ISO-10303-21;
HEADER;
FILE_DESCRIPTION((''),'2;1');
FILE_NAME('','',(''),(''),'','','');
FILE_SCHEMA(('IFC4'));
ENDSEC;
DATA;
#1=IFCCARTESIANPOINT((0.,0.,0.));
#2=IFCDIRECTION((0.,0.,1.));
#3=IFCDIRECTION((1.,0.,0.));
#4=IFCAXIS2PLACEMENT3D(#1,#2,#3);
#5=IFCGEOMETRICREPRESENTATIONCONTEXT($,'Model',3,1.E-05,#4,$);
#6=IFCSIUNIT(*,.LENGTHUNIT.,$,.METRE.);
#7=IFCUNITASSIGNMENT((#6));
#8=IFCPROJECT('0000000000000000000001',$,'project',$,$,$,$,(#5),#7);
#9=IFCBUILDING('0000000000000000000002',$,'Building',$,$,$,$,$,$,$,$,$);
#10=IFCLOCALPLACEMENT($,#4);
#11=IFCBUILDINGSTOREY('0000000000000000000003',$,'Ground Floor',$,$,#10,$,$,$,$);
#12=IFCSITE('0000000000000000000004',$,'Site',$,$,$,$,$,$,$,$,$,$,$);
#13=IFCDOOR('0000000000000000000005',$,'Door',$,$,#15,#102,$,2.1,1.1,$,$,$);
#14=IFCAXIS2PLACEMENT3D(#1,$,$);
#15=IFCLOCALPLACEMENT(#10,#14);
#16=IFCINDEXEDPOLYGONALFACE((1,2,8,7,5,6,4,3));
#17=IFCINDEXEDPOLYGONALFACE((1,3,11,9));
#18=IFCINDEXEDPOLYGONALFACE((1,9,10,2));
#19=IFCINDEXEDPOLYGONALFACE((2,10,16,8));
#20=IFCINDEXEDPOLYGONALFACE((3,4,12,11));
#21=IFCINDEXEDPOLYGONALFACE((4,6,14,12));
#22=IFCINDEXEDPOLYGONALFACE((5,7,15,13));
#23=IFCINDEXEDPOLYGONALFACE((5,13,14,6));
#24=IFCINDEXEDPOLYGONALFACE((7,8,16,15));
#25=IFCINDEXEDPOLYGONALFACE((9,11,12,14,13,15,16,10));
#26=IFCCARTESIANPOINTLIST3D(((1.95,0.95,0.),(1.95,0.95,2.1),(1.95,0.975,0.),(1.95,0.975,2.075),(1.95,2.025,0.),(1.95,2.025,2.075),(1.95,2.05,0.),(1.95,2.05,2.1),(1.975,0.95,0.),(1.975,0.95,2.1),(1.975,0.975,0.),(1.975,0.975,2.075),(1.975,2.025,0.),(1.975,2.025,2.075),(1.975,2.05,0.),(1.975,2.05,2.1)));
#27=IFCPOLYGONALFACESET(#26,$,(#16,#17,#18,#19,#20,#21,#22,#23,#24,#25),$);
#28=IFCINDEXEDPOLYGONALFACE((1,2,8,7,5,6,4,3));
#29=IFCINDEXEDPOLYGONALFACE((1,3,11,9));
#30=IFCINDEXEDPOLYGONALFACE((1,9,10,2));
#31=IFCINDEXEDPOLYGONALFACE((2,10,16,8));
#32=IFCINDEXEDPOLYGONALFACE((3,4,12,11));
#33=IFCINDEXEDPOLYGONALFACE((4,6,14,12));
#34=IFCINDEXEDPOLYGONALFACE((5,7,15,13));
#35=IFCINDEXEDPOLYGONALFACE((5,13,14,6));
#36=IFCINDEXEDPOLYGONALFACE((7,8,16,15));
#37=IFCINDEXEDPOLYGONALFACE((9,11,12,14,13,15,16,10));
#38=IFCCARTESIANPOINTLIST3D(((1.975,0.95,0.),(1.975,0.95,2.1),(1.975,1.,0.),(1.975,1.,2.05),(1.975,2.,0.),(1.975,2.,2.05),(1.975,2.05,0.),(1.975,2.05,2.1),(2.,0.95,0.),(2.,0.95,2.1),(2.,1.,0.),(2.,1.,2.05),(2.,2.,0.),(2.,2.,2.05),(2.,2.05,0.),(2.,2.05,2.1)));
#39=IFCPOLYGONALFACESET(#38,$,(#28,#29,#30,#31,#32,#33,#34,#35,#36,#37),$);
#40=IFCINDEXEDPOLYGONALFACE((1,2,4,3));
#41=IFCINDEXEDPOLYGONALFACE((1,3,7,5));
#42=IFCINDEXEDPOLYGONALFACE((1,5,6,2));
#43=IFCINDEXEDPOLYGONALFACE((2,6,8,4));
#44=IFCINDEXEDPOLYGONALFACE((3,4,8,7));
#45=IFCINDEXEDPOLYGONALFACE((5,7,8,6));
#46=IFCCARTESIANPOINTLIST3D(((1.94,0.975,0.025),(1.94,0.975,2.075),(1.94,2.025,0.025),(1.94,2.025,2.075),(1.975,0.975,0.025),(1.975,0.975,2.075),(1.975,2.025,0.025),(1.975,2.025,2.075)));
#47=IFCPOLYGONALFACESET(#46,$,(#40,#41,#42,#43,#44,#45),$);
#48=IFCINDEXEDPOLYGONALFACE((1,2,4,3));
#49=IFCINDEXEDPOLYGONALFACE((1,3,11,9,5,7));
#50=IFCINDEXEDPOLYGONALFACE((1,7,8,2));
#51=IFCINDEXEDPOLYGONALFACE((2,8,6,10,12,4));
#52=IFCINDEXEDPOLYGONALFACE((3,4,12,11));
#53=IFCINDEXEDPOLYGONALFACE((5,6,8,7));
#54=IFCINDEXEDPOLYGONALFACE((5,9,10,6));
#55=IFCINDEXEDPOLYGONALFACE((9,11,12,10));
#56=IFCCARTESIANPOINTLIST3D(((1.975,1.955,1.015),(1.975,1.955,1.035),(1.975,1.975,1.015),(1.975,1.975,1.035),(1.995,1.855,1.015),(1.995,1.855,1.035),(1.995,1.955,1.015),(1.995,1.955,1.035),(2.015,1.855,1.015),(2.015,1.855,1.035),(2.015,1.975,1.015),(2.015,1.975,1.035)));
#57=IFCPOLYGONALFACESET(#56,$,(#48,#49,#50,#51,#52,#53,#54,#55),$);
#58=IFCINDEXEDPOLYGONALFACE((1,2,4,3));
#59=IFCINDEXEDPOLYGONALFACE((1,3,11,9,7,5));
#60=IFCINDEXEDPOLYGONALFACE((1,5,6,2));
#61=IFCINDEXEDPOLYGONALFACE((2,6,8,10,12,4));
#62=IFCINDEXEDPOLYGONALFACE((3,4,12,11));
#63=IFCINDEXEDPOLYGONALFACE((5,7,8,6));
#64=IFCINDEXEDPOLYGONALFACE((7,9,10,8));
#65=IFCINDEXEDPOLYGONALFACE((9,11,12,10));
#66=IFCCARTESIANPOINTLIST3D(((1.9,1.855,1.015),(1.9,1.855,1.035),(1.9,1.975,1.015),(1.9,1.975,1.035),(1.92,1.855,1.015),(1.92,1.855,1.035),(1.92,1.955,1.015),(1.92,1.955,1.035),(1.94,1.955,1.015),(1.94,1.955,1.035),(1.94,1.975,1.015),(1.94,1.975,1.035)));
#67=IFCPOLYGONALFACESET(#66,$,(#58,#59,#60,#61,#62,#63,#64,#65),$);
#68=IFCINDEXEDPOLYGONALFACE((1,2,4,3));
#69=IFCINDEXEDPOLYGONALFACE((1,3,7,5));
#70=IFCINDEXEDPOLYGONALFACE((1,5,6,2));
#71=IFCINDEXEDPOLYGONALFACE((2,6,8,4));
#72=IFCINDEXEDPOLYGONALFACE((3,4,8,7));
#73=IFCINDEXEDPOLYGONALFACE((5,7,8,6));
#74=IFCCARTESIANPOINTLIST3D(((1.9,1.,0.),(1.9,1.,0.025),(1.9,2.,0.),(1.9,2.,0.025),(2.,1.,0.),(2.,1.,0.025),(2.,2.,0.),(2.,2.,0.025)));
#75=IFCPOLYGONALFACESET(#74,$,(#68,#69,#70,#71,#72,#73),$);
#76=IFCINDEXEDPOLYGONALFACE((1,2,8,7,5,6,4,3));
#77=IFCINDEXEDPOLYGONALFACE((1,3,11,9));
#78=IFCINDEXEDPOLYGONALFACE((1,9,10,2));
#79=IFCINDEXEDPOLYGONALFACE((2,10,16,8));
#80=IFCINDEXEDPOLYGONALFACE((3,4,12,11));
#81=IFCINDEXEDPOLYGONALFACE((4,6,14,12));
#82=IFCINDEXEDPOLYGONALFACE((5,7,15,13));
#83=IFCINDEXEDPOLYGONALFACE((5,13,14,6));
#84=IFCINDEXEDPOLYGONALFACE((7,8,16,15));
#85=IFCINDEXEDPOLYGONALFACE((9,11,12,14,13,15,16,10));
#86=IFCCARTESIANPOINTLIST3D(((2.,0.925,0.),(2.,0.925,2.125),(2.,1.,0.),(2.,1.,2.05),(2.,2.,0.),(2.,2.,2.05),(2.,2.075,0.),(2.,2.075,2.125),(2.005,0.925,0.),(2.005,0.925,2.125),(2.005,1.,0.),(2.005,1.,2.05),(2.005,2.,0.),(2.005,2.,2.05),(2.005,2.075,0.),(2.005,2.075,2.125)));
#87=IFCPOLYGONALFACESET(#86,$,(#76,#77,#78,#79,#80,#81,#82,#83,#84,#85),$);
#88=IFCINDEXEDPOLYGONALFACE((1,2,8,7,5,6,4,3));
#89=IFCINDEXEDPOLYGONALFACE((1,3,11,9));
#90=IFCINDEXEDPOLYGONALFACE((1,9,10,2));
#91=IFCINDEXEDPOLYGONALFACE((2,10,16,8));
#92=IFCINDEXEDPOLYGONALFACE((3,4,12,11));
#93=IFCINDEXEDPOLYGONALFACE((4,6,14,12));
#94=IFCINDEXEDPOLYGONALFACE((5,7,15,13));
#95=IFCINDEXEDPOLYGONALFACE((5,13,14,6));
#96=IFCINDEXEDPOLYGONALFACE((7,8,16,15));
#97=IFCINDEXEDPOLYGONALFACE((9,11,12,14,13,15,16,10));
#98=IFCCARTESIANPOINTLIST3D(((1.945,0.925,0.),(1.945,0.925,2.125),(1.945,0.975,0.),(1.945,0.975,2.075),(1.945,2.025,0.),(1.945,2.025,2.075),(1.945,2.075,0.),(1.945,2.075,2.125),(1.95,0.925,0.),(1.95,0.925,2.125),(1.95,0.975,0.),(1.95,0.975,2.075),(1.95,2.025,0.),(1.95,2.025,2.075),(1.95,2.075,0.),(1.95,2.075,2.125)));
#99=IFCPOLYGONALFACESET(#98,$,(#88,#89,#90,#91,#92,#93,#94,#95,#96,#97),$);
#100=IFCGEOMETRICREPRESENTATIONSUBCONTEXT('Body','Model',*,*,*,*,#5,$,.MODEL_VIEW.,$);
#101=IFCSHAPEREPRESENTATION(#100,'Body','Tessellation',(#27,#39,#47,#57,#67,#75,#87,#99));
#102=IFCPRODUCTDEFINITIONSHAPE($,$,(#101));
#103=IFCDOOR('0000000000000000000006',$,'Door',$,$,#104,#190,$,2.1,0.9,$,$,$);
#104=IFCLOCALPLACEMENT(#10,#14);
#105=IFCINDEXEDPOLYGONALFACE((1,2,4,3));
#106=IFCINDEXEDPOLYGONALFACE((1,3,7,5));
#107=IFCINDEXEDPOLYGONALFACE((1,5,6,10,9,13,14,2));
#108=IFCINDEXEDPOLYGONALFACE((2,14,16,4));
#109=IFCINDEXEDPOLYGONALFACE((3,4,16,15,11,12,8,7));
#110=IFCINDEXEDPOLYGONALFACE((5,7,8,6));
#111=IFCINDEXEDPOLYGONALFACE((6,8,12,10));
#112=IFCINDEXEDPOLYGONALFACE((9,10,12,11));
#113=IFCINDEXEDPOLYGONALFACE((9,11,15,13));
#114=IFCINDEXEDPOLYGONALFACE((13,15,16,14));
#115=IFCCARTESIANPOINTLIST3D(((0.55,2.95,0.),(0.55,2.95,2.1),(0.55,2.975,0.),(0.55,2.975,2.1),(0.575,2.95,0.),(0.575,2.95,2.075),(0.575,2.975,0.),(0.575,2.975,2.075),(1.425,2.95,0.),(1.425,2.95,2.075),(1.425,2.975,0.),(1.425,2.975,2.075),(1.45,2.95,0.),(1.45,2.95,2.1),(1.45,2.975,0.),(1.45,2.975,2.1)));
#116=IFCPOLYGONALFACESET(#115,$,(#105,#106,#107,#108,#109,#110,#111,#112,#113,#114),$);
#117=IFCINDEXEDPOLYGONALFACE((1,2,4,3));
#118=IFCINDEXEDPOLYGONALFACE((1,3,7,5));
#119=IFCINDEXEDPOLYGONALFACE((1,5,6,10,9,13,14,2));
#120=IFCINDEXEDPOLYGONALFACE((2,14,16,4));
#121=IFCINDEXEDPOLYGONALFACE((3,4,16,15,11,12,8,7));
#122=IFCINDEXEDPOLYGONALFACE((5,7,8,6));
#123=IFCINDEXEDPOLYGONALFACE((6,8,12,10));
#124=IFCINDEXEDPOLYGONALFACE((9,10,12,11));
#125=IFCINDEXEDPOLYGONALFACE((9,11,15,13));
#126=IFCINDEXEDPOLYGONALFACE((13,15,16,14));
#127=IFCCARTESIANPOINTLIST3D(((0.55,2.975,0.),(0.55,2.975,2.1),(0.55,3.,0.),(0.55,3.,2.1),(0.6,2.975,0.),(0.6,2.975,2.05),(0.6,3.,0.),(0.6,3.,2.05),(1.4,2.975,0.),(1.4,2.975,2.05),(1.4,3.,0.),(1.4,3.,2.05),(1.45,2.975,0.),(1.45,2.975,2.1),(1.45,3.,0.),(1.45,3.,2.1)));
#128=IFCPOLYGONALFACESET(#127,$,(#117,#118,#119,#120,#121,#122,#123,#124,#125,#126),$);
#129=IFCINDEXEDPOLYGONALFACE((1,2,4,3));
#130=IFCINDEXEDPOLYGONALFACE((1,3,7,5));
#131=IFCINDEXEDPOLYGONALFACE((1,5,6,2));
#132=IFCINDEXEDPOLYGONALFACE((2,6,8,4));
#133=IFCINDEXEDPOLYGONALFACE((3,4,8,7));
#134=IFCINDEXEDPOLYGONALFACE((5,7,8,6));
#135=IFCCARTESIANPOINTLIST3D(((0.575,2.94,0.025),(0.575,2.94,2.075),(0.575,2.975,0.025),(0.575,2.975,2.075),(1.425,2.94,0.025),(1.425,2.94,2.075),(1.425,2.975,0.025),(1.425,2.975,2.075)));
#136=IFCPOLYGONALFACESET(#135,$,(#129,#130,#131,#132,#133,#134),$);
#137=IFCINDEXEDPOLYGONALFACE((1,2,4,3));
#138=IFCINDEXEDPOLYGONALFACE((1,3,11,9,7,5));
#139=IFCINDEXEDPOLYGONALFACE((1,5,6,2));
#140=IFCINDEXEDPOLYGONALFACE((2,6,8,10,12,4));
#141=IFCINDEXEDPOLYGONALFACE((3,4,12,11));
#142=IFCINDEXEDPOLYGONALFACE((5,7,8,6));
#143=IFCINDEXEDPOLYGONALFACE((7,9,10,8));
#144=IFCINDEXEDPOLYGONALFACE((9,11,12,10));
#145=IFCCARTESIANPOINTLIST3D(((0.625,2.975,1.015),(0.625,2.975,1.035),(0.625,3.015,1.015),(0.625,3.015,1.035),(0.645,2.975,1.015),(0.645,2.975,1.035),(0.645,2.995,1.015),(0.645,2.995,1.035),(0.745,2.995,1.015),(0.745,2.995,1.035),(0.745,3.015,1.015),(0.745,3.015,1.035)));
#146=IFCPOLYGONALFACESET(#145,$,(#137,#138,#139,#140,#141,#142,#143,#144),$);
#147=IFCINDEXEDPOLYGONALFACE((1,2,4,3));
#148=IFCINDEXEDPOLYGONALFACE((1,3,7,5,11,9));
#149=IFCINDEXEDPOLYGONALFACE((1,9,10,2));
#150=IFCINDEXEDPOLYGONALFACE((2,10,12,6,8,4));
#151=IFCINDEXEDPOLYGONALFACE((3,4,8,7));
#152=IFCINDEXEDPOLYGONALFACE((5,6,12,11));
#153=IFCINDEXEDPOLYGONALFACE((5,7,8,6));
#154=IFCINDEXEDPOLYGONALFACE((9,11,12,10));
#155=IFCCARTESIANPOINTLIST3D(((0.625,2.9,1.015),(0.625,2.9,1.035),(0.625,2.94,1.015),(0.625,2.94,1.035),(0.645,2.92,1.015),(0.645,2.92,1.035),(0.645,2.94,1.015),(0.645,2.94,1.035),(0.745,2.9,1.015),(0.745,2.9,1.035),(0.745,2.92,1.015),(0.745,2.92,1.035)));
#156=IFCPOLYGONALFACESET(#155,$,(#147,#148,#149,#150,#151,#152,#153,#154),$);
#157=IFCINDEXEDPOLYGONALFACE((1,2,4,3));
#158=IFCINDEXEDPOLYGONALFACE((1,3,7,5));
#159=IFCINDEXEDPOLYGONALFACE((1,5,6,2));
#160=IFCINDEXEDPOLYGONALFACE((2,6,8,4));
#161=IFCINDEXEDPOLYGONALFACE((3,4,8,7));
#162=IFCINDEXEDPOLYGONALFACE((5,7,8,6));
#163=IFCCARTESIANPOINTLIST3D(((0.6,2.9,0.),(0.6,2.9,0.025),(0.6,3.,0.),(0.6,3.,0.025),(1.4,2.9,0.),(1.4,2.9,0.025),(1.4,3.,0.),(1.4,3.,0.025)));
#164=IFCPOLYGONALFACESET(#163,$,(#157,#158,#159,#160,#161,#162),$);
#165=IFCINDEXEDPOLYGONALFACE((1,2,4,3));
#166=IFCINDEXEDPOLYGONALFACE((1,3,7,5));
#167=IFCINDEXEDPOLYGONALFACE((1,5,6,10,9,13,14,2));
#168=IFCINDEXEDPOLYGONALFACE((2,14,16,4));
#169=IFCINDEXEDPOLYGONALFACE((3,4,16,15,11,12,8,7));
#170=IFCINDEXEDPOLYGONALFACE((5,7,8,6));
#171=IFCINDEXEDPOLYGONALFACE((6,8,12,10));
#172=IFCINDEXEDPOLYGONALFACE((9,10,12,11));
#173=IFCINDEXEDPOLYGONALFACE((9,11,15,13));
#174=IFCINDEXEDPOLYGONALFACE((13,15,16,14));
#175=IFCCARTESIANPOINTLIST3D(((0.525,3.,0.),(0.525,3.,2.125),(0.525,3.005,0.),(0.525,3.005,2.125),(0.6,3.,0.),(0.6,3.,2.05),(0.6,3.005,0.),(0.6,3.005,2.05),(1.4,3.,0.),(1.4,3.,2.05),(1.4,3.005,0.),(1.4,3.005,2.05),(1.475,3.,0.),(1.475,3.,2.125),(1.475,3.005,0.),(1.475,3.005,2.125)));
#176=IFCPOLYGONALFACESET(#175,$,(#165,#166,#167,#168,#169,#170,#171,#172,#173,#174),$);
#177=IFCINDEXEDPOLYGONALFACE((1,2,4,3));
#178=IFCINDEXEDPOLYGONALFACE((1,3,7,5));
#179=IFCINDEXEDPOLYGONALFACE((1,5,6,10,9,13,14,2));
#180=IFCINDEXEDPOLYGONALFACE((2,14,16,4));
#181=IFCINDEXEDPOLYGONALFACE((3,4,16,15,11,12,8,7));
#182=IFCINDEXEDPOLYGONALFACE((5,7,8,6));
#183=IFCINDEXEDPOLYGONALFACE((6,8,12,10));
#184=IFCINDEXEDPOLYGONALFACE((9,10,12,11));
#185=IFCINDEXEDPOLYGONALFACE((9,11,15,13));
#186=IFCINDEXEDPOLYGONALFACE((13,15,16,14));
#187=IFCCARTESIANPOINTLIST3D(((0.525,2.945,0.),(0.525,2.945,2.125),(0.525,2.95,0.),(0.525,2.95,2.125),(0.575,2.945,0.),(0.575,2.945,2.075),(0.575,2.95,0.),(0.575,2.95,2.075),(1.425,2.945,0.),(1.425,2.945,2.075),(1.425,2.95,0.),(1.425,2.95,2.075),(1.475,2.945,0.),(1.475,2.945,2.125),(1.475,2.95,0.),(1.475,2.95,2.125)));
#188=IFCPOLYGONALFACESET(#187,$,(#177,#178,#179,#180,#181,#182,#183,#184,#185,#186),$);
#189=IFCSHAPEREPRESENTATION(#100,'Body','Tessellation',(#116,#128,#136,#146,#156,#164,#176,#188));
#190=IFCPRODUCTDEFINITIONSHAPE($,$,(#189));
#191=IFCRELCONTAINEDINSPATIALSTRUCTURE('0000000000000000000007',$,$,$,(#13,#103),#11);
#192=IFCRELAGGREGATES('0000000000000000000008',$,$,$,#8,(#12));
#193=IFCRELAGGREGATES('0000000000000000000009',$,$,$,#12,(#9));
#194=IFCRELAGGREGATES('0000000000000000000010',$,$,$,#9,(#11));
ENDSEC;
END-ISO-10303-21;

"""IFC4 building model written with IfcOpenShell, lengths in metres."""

from ifc_helpers import new_model, si_unit, frame, origin_with_axes, place, context, subcontext, project, spatial, line, indexed_curve, outline, extrude, element, save


model = new_model("IFC4")

# Units and contexts
model_context = context("Model", 3, precision=1e-05, world=origin_with_axes())
body_context = subcontext(model_context, "Body", "Model", "MODEL_VIEW")
ifc_project = project(units=[si_unit("LENGTHUNIT", "METRE")], contexts=[model_context])

# Site, building, storey
site = spatial("IfcSite", under=ifc_project, Name="Site")
building = spatial("IfcBuilding", under=site, Name="Building")
storey_placement = place(None, origin_with_axes())
storey = spatial("IfcBuildingStorey", under=building, at=storey_placement, Name="Ground Floor")

# Doors
door_1_placement = place(storey_placement, frame((2.0, 0.95, 0.0), z_axis=(0.0, 0.0, 1.0), x_axis=(0.0, 1.0, 0.0)))
element("IfcDoor", 1, at=door_1_placement, inside=storey, Name="Door", OverallHeight=2.1, OverallWidth=1.1, context=body_context, shape_type="SweptSolid", body=[
    extrude(outline(indexed_curve([(0.0, 0.0), (0.0, 2.1), (1.1, 2.1), (1.1, 0.0), (1.075, 0.0), (1.075, 2.075), (0.025, 2.075), (0.025, 0.0)], segments=[line(1, 2, 3, 4, 5, 6, 7, 8, 1)])), frame((0.0, 0.025, 0.0), z_axis=(0.0, -1.0, 0.0), x_axis=(1.0, 0.0, 0.0)), (0.0, 0.0, -1.0), 0.025),
    extrude(outline(indexed_curve([(0.0, 0.0), (0.0, 2.1), (1.1, 2.1), (1.1, 0.0), (1.05, 0.0), (1.05, 2.05), (0.05, 2.05), (0.05, 0.0)], segments=[line(1, 2, 3, 4, 5, 6, 7, 8, 1)])), frame((0.0, 0.0, 0.0), z_axis=(0.0, -1.0, 0.0), x_axis=(1.0, 0.0, 0.0)), (0.0, 0.0, -1.0), 0.025),
    extrude(outline(indexed_curve([(0.0, 0.0), (1.05, 0.0), (1.05, 0.035), (0.0, 0.035)], segments=[line(1, 2, 3, 4, 1)])), frame((0.025, 0.025, 0.025), z_axis=(0.0, 0.0, 1.0), x_axis=(1.0, 0.0, 0.0)), (0.0, 0.0, 1.0), 2.05),
    extrude(outline(indexed_curve([(0.0, 0.0), (0.0, -0.04), (-0.12, -0.04), (-0.12, -0.02), (-0.02, -0.02), (-0.02, 0.0)], segments=[line(1, 2, 3, 4, 5, 6, 1)])), frame((1.025, 0.025, 1.015), z_axis=(0.0, 0.0, 1.0), x_axis=(1.0, 0.0, 0.0)), (0.0, 0.0, 1.0), 0.02),
    extrude(outline(indexed_curve([(0.0, 0.0), (0.0, 0.04), (-0.12, 0.04), (-0.12, 0.02), (-0.02, 0.02), (-0.02, 0.0)], segments=[line(1, 2, 3, 4, 5, 6, 1)])), frame((1.025, 0.06, 1.015), z_axis=(0.0, 0.0, 1.0), x_axis=(1.0, 0.0, 0.0)), (0.0, 0.0, 1.0), 0.02),
    extrude(outline(indexed_curve([(0.0, 0.0), (1.0, 0.0), (1.0, 0.1), (0.0, 0.1)], segments=[line(1, 2, 3, 4, 1)])), frame((0.05, 0.0, 0.0), z_axis=(0.0, 0.0, 1.0), x_axis=(1.0, 0.0, 0.0)), (0.0, 0.0, 1.0), 0.025),
    extrude(outline(indexed_curve([(0.0, 0.0), (0.0, 2.125), (1.15, 2.125), (1.15, 0.0), (1.075, 0.0), (1.075, 2.05), (0.075, 2.05), (0.075, 0.0)], segments=[line(1, 2, 3, 4, 5, 6, 7, 8, 1)])), frame((-0.025, -0.005, 0.0), z_axis=(0.0, -1.0, 0.0), x_axis=(1.0, 0.0, 0.0)), (0.0, 0.0, -1.0), 0.005),
    extrude(outline(indexed_curve([(0.0, 0.0), (0.0, 2.125), (1.15, 2.125), (1.15, 0.0), (1.1, 0.0), (1.1, 2.075), (0.05, 2.075), (0.05, 0.0)], segments=[line(1, 2, 3, 4, 5, 6, 7, 8, 1)])), frame((-0.025, 0.05, 0.0), z_axis=(0.0, -1.0, 0.0), x_axis=(1.0, 0.0, 0.0)), (0.0, 0.0, -1.0), 0.005),
])
door_2_placement = place(storey_placement, frame((1.45, 3.0, 0.0), z_axis=(0.0, 0.0, 1.0), x_axis=(-1.0, 0.0, 0.0)))
element("IfcDoor", 2, at=door_2_placement, inside=storey, Name="Door", OverallHeight=2.1, OverallWidth=0.9, context=body_context, shape_type="SweptSolid", body=[
    extrude(outline(indexed_curve([(0.0, 0.0), (0.0, 2.1), (0.9, 2.1), (0.9, 0.0), (0.875, 0.0), (0.875, 2.075), (0.025, 2.075), (0.025, 0.0)], segments=[line(1, 2, 3, 4, 5, 6, 7, 8, 1)])), frame((0.0, 0.025, 0.0), z_axis=(0.0, -1.0, 0.0), x_axis=(1.0, 0.0, 0.0)), (0.0, 0.0, -1.0), 0.025),
    extrude(outline(indexed_curve([(0.0, 0.0), (0.0, 2.1), (0.9, 2.1), (0.9, 0.0), (0.85, 0.0), (0.85, 2.05), (0.05, 2.05), (0.05, 0.0)], segments=[line(1, 2, 3, 4, 5, 6, 7, 8, 1)])), frame((0.0, 0.0, 0.0), z_axis=(0.0, -1.0, 0.0), x_axis=(1.0, 0.0, 0.0)), (0.0, 0.0, -1.0), 0.025),
    extrude(outline(indexed_curve([(0.0, 0.0), (0.85, 0.0), (0.85, 0.035), (0.0, 0.035)], segments=[line(1, 2, 3, 4, 1)])), frame((0.025, 0.025, 0.025), z_axis=(0.0, 0.0, 1.0), x_axis=(1.0, 0.0, 0.0)), (0.0, 0.0, 1.0), 2.05),
    extrude(outline(indexed_curve([(0.0, 0.0), (0.0, -0.04), (-0.12, -0.04), (-0.12, -0.02), (-0.02, -0.02), (-0.02, 0.0)], segments=[line(1, 2, 3, 4, 5, 6, 1)])), frame((0.825, 0.025, 1.015), z_axis=(0.0, 0.0, 1.0), x_axis=(1.0, 0.0, 0.0)), (0.0, 0.0, 1.0), 0.02),
    extrude(outline(indexed_curve([(0.0, 0.0), (0.0, 0.04), (-0.12, 0.04), (-0.12, 0.02), (-0.02, 0.02), (-0.02, 0.0)], segments=[line(1, 2, 3, 4, 5, 6, 1)])), frame((0.825, 0.06, 1.015), z_axis=(0.0, 0.0, 1.0), x_axis=(1.0, 0.0, 0.0)), (0.0, 0.0, 1.0), 0.02),
    extrude(outline(indexed_curve([(0.0, 0.0), (0.8, 0.0), (0.8, 0.1), (0.0, 0.1)], segments=[line(1, 2, 3, 4, 1)])), frame((0.05, 0.0, 0.0), z_axis=(0.0, 0.0, 1.0), x_axis=(1.0, 0.0, 0.0)), (0.0, 0.0, 1.0), 0.025),
    extrude(outline(indexed_curve([(0.0, 0.0), (0.0, 2.125), (0.95, 2.125), (0.95, 0.0), (0.875, 0.0), (0.875, 2.05), (0.075, 2.05), (0.075, 0.0)], segments=[line(1, 2, 3, 4, 5, 6, 7, 8, 1)])), frame((-0.025, -0.005, 0.0), z_axis=(0.0, -1.0, 0.0), x_axis=(1.0, 0.0, 0.0)), (0.0, 0.0, -1.0), 0.005),
    extrude(outline(indexed_curve([(0.0, 0.0), (0.0, 2.125), (0.95, 2.125), (0.95, 0.0), (0.9, 0.0), (0.9, 2.075), (0.05, 2.075), (0.05, 0.0)], segments=[line(1, 2, 3, 4, 5, 6, 7, 8, 1)])), frame((-0.025, 0.05, 0.0), z_axis=(0.0, -1.0, 0.0), x_axis=(1.0, 0.0, 0.0)), (0.0, 0.0, -1.0), 0.005),
])

save(model, "model.ifc")
